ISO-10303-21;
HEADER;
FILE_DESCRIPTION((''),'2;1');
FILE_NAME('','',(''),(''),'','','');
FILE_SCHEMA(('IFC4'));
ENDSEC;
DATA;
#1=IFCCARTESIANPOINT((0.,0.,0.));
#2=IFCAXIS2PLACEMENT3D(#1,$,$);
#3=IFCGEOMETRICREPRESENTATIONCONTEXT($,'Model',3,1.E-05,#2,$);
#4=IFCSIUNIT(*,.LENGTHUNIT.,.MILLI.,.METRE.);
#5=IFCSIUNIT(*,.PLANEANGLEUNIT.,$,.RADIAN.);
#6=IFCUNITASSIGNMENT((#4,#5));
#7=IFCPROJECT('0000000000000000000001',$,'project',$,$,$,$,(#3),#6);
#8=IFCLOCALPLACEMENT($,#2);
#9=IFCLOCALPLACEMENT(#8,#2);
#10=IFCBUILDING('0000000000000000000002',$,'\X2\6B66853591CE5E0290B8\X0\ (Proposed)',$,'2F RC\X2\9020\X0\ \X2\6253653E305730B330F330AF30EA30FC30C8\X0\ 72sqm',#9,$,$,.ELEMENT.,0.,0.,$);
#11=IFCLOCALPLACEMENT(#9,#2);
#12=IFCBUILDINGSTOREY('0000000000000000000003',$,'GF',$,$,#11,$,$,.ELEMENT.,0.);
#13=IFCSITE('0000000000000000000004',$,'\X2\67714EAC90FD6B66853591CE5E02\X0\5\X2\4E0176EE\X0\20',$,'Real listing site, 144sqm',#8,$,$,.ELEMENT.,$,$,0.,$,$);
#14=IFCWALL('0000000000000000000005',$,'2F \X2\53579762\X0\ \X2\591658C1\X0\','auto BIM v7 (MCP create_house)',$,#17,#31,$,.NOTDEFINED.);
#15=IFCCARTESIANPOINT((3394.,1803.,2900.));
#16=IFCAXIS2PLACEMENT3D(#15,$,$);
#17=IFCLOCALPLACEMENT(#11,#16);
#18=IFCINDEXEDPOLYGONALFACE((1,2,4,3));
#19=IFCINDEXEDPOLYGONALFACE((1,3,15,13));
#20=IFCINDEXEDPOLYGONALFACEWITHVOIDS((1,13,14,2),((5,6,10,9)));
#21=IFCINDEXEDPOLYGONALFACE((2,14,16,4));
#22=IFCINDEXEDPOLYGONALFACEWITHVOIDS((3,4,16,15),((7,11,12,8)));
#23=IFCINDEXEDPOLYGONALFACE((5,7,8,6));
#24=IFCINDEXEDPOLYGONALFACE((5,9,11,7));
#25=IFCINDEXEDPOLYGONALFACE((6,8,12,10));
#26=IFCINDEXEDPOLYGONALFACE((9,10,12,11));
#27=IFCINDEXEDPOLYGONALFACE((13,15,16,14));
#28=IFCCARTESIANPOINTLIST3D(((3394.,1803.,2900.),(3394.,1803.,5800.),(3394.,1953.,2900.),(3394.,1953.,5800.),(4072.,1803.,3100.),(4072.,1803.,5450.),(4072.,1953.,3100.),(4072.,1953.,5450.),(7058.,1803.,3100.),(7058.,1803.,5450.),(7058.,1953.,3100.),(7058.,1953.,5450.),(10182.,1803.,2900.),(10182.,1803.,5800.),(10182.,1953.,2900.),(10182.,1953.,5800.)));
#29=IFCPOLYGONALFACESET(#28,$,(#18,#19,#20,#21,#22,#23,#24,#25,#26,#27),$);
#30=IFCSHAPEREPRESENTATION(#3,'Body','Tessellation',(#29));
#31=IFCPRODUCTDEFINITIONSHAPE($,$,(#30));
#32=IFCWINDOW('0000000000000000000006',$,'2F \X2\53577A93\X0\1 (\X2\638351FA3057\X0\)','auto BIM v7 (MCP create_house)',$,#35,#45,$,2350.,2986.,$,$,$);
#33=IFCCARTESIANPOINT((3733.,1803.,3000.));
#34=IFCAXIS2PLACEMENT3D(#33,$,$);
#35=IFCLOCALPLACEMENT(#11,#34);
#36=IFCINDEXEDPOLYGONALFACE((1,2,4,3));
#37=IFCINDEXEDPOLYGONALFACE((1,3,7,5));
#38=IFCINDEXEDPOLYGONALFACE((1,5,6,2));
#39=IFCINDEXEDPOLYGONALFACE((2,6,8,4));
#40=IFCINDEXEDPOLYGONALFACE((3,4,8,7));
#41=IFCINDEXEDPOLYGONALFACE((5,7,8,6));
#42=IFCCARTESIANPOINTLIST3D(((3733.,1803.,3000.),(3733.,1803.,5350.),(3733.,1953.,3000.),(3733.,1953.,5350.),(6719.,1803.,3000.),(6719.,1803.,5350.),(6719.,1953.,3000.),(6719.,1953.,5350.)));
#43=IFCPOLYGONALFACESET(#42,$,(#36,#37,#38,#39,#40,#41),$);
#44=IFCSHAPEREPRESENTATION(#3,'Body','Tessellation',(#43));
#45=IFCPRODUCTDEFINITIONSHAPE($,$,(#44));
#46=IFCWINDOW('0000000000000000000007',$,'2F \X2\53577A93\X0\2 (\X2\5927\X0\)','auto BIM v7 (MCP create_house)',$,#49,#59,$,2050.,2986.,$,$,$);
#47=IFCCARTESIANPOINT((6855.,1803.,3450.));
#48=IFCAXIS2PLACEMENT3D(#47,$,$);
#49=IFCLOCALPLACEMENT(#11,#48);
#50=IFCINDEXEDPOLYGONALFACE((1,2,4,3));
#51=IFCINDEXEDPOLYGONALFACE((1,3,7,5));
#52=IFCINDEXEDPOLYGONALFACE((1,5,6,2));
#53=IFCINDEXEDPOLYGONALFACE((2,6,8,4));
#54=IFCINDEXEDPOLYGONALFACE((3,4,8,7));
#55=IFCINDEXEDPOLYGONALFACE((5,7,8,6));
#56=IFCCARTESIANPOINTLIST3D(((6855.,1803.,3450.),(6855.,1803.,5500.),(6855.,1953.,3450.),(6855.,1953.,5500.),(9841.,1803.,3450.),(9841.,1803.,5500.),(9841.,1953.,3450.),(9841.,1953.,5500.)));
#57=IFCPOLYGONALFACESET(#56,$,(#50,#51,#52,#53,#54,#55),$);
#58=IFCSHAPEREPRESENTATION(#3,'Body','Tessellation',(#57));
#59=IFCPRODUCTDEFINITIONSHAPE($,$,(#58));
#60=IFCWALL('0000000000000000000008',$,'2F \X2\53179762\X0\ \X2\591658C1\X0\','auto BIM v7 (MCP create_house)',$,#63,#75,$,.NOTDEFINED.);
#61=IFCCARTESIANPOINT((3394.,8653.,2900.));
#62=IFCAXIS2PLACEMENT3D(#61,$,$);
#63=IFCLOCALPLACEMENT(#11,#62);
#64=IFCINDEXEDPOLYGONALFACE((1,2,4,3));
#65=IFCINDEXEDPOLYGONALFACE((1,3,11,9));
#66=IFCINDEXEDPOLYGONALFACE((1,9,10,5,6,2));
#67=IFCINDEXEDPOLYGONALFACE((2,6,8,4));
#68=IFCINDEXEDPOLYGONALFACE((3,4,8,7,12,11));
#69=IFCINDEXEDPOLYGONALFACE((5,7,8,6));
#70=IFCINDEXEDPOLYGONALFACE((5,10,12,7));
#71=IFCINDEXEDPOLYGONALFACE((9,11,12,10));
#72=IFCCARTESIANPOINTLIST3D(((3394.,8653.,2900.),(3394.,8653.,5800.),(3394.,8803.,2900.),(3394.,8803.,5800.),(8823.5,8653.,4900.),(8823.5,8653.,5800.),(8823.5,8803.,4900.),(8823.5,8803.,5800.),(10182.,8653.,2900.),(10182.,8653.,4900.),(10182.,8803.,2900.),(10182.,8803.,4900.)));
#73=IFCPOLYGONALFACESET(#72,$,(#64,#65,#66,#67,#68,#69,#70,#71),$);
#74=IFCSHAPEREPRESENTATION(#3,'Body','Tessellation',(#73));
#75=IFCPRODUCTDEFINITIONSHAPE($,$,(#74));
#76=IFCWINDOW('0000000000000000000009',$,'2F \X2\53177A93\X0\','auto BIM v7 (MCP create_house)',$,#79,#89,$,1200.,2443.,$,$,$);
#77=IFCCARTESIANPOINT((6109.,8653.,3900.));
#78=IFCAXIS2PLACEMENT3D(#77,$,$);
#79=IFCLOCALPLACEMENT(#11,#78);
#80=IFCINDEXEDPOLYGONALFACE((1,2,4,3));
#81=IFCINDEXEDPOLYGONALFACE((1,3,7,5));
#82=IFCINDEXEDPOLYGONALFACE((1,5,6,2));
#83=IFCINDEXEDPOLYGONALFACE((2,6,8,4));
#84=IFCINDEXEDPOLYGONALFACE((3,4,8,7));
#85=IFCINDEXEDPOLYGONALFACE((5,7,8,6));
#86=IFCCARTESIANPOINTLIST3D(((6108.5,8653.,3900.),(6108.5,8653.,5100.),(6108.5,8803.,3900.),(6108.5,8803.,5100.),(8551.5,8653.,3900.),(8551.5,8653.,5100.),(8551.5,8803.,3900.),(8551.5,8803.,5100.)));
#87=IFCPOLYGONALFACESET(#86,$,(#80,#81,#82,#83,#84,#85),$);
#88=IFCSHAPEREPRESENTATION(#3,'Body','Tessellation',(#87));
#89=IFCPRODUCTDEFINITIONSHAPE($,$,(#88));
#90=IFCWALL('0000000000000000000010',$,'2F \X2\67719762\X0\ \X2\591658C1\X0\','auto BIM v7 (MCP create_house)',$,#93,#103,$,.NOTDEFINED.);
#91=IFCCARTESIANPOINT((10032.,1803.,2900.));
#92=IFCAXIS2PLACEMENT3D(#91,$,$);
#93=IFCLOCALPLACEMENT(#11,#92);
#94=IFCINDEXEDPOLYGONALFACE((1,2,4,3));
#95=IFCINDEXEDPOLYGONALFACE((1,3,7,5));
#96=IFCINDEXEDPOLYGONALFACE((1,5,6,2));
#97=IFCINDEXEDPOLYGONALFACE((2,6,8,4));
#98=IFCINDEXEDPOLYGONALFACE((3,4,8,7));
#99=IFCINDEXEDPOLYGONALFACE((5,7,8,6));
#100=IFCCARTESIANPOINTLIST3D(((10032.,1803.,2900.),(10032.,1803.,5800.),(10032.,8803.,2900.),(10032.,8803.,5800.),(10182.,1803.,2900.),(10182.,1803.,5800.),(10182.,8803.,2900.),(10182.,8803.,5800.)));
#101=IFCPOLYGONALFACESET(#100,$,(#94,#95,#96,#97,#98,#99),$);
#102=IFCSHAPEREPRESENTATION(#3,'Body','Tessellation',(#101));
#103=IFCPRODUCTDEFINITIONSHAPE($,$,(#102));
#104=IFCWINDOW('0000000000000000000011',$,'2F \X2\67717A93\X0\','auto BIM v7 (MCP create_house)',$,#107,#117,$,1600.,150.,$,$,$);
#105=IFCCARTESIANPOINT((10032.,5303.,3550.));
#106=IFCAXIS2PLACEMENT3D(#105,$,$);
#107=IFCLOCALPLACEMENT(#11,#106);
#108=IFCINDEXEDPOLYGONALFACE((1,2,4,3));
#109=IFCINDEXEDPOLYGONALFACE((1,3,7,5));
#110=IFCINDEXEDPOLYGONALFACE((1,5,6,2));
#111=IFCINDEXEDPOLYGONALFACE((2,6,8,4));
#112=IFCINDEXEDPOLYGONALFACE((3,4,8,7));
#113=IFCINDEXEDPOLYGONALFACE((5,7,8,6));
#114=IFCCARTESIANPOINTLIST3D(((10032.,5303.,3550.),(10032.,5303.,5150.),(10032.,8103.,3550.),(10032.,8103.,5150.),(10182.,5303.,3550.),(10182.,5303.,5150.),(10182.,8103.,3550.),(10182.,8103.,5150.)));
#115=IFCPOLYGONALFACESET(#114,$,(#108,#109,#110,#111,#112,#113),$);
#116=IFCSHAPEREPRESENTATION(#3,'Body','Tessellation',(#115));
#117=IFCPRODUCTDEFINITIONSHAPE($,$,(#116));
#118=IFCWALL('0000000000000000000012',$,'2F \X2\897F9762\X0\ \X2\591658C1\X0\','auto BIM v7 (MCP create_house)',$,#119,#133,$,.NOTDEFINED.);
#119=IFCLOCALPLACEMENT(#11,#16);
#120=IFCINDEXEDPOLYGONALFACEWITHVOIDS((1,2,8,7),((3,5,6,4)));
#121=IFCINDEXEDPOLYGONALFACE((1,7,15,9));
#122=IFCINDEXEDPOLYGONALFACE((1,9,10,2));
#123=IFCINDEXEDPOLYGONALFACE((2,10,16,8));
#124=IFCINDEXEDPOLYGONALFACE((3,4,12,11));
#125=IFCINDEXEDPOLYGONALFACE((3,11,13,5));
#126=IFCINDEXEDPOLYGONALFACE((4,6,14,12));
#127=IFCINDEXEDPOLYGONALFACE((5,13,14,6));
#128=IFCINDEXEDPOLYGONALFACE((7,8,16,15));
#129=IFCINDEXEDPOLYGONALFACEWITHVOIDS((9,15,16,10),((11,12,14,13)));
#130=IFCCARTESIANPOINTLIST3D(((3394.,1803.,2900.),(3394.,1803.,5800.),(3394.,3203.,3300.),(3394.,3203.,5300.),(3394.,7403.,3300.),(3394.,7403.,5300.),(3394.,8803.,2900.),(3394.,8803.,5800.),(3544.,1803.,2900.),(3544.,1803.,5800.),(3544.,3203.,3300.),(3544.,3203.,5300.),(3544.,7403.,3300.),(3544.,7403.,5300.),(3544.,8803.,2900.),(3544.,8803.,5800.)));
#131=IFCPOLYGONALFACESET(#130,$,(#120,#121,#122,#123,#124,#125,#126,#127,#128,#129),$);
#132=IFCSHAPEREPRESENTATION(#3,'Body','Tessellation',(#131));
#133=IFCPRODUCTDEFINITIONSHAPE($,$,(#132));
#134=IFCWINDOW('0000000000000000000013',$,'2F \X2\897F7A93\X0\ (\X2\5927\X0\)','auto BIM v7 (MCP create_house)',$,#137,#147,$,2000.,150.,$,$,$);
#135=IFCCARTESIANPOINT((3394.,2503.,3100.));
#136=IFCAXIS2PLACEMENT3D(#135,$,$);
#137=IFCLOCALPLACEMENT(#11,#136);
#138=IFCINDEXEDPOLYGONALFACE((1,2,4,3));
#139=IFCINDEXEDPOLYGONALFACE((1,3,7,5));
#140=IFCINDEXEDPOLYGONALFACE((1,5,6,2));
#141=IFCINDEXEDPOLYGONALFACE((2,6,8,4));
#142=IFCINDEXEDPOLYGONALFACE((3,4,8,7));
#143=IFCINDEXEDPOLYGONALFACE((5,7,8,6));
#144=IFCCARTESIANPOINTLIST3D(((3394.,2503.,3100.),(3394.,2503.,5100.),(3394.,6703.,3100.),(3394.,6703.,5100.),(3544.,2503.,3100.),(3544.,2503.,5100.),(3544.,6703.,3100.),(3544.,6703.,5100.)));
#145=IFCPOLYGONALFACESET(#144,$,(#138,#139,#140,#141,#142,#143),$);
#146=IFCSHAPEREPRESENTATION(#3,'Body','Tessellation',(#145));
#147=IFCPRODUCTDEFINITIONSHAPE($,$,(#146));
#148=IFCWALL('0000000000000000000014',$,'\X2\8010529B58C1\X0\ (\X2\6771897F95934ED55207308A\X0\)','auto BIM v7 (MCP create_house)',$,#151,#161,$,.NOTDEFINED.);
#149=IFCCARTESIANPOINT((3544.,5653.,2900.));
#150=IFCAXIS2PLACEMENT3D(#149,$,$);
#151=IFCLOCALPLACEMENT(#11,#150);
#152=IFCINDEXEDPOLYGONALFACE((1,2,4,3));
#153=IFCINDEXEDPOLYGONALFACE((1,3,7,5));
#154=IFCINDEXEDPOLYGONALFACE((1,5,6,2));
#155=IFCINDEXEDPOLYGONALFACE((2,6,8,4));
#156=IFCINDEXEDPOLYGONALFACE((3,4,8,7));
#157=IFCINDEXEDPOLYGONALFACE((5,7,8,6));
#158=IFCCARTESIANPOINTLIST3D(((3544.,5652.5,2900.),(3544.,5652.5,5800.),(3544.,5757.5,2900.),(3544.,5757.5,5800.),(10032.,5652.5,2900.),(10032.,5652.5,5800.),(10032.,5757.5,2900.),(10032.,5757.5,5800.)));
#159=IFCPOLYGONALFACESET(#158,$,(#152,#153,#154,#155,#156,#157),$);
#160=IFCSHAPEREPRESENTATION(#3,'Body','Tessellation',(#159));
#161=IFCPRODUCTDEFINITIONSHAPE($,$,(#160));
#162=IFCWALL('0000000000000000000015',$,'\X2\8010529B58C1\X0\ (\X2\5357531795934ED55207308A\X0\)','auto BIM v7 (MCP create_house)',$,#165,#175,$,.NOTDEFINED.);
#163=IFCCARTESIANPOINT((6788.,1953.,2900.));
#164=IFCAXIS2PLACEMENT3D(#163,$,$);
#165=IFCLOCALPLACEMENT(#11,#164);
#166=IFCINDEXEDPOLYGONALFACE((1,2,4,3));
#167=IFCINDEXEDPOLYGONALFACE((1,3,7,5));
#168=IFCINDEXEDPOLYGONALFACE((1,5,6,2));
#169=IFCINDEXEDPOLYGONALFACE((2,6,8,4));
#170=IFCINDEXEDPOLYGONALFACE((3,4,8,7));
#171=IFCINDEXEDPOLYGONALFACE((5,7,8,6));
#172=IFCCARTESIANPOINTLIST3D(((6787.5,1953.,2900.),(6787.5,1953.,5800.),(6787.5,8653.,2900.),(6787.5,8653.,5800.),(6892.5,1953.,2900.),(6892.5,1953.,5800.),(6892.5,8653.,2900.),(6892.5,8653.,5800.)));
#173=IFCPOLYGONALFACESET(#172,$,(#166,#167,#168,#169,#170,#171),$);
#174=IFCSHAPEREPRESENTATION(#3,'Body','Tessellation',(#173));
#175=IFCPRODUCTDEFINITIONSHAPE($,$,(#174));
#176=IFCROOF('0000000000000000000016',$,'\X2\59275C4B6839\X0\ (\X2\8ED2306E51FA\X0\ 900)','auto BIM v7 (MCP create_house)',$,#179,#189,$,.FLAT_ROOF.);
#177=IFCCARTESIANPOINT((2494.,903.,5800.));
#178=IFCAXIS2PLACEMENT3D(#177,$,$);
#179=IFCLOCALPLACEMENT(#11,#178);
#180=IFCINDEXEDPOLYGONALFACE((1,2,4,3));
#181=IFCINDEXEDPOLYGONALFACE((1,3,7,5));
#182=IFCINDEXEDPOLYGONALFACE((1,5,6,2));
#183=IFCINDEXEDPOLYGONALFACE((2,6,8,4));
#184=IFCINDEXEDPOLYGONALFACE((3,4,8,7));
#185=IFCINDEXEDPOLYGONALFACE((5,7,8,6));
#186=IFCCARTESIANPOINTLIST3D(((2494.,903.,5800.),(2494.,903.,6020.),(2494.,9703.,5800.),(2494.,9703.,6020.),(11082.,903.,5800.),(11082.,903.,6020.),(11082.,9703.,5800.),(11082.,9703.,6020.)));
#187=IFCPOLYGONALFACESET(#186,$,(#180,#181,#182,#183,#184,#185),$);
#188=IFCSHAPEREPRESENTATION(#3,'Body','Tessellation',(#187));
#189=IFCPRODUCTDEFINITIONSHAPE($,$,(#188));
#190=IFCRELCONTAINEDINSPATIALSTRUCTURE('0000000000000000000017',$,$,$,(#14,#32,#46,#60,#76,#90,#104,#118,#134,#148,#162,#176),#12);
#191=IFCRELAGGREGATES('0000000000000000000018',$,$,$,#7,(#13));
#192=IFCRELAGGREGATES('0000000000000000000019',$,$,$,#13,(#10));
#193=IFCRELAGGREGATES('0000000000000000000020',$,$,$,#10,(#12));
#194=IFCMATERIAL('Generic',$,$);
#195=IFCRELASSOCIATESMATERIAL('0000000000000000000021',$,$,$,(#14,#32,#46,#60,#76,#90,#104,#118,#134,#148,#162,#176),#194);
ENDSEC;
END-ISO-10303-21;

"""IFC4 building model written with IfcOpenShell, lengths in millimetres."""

from ifc_helpers import new_model, si_unit, frame, frame_2d, origin, place, context, project, spatial, rectangle, extrude, material, element, fill, save


model = new_model("IFC4")

# Units and contexts
model_context = context("Model", 3, precision=1e-05, world=origin())
ifc_project = project(units=[si_unit("LENGTHUNIT", "METRE", prefix="MILLI"), si_unit("PLANEANGLEUNIT", "RADIAN")], contexts=[model_context])

# Site, building, storey
site_placement = place(None, origin())
site = spatial("IfcSite", under=ifc_project, at=site_placement, Name="東京都武蔵野市5丁目20", ObjectType="Real listing site, 144sqm", CompositionType="ELEMENT", RefElevation=0.0)
building_placement = place(site_placement, origin())
building = spatial("IfcBuilding", under=site, at=building_placement, Name="武蔵野市邸 (Proposed)", ObjectType="2F RC造 打放しコンクリート 72sqm", CompositionType="ELEMENT", ElevationOfRefHeight=0.0, ElevationOfTerrain=0.0)
storey_placement = place(building_placement, origin())
storey = spatial("IfcBuildingStorey", under=building, at=storey_placement, Name="GF", CompositionType="ELEMENT", Elevation=0.0)

# Shared definitions
ifc_material = material(Name="Generic")

# Wall, openings, windows
wall_1_placement = place(storey_placement, frame((3394.0, 1803.0, 2900.0)))
wall_1 = element("IfcWall", 1, at=wall_1_placement, inside=storey, material=ifc_material, Name="2F 南面 外壁", Description="auto BIM v7 (MCP create_house)", PredefinedType="NOTDEFINED", context=model_context, shape_type="SweptSolid", body=[
    extrude(rectangle(XDim=6788.0, YDim=150.0, at=frame_2d((3394.0, 75.0))), frame((3394.0, 1803.0, 2900.0)), (0.0, 0.0, 1.0), 2900.0),
])
opening_1_placement = place(storey_placement, frame((3733.0, 1803.0, 3000.0)))
opening_1 = element("IfcOpeningElement", 2, at=opening_1_placement, cuts=wall_1, PredefinedType="NOTDEFINED", context=model_context, shape_type="SweptSolid", body=[
    extrude(rectangle(XDim=2986.0, YDim=150.0, at=frame_2d((1493.0, 75.0))), frame((3733.0, 1803.0, 3000.0)), (0.0, 0.0, 1.0), 2350.0),
])
opening_2_placement = place(storey_placement, frame((6855.0, 1803.0, 3450.0)))
opening_2 = element("IfcOpeningElement", 3, at=opening_2_placement, cuts=wall_1, PredefinedType="NOTDEFINED", context=model_context, shape_type="SweptSolid", body=[
    extrude(rectangle(XDim=2986.0, YDim=150.0, at=frame_2d((1493.0, 75.0))), frame((6855.0, 1803.0, 3450.0)), (0.0, 0.0, 1.0), 2050.0),
])
window_1_placement = place(storey_placement, frame((3733.0, 1803.0, 3000.0)))
window_1 = element("IfcWindow", 4, at=window_1_placement, inside=storey, material=ifc_material, Name="2F 南窓1 (掃出し)", Description="auto BIM v7 (MCP create_house)", OverallHeight=2350.0, OverallWidth=2986.0, context=model_context, shape_type="SweptSolid", body=[
    extrude(rectangle(XDim=2986.0, YDim=150.0, at=frame_2d((1493.0, 75.0))), frame((3733.0, 1803.0, 3000.0)), (0.0, 0.0, 1.0), 2350.0),
])
fill(opening_1, window_1)
window_2_placement = place(storey_placement, frame((6855.0, 1803.0, 3450.0)))
window_2 = element("IfcWindow", 5, at=window_2_placement, inside=storey, material=ifc_material, Name="2F 南窓2 (大)", Description="auto BIM v7 (MCP create_house)", OverallHeight=2050.0, OverallWidth=2986.0, context=model_context, shape_type="SweptSolid", body=[
    extrude(rectangle(XDim=2986.0, YDim=150.0, at=frame_2d((1493.0, 75.0))), frame((6855.0, 1803.0, 3450.0)), (0.0, 0.0, 1.0), 2050.0),
])
fill(opening_2, window_2)

# Walls, openings, windows
wall_2_placement = place(storey_placement, frame((3394.0, 8653.0, 2900.0)))
wall_2 = element("IfcWall", 6, at=wall_2_placement, inside=storey, material=ifc_material, Name="2F 北面 外壁", Description="auto BIM v7 (MCP create_house)", PredefinedType="NOTDEFINED", context=model_context, shape_type="SweptSolid", body=[
    extrude(rectangle(XDim=6788.0, YDim=150.0, at=frame_2d((3394.0, 75.0))), frame((3394.0, 8653.0, 2900.0)), (0.0, 0.0, 1.0), 2900.0),
])
opening_3_placement = place(storey_placement, frame((6109.0, 8653.0, 3900.0)))
opening_3 = element("IfcOpeningElement", 7, at=opening_3_placement, cuts=wall_2, PredefinedType="NOTDEFINED", context=model_context, shape_type="SweptSolid", body=[
    extrude(rectangle(XDim=2443.0, YDim=150.0, at=frame_2d((1221.0, 75.0))), frame((6109.0, 8653.0, 3900.0)), (0.0, 0.0, 1.0), 1200.0),
])
window_3_placement = place(storey_placement, frame((6109.0, 8653.0, 3900.0)))
window_3 = element("IfcWindow", 8, at=window_3_placement, inside=storey, material=ifc_material, Name="2F 北窓", Description="auto BIM v7 (MCP create_house)", OverallHeight=1200.0, OverallWidth=2443.0, context=model_context, shape_type="SweptSolid", body=[
    extrude(rectangle(XDim=2443.0, YDim=150.0, at=frame_2d((1221.0, 75.0))), frame((6109.0, 8653.0, 3900.0)), (0.0, 0.0, 1.0), 1200.0),
])
fill(opening_3, window_3)
wall_3_placement = place(storey_placement, frame((10032.0, 1803.0, 2900.0)))
wall_3 = element("IfcWall", 9, at=wall_3_placement, inside=storey, material=ifc_material, Name="2F 東面 外壁", Description="auto BIM v7 (MCP create_house)", PredefinedType="NOTDEFINED", context=model_context, shape_type="SweptSolid", body=[
    extrude(rectangle(XDim=150.0, YDim=7000.0, at=frame_2d((75.0, 3500.0))), frame((10032.0, 1803.0, 2900.0)), (0.0, 0.0, 1.0), 2900.0),
])
opening_4_placement = place(storey_placement, frame((10032.0, 5303.0, 3550.0)))
opening_4 = element("IfcOpeningElement", 10, at=opening_4_placement, cuts=wall_3, PredefinedType="NOTDEFINED", context=model_context, shape_type="SweptSolid", body=[
    extrude(rectangle(XDim=150.0, YDim=2800.0, at=frame_2d((75.0, 1400.0))), frame((10032.0, 5303.0, 3550.0)), (0.0, 0.0, 1.0), 1600.0),
])
window_4_placement = place(storey_placement, frame((10032.0, 5303.0, 3550.0)))
window_4 = element("IfcWindow", 11, at=window_4_placement, inside=storey, material=ifc_material, Name="2F 東窓", Description="auto BIM v7 (MCP create_house)", OverallHeight=1600.0, OverallWidth=150.0, context=model_context, shape_type="SweptSolid", body=[
    extrude(rectangle(XDim=150.0, YDim=2800.0, at=frame_2d((75.0, 1400.0))), frame((10032.0, 5303.0, 3550.0)), (0.0, 0.0, 1.0), 1600.0),
])
fill(opening_4, window_4)
wall_4_placement = place(storey_placement, frame((3394.0, 1803.0, 2900.0)))
wall_4 = element("IfcWall", 12, at=wall_4_placement, inside=storey, material=ifc_material, Name="2F 西面 外壁", Description="auto BIM v7 (MCP create_house)", PredefinedType="NOTDEFINED", context=model_context, shape_type="SweptSolid", body=[
    extrude(rectangle(XDim=150.0, YDim=7000.0, at=frame_2d((75.0, 3500.0))), frame((3394.0, 1803.0, 2900.0)), (0.0, 0.0, 1.0), 2900.0),
])
opening_5_placement = place(storey_placement, frame((3394.0, 2503.0, 3100.0)))
opening_5 = element("IfcOpeningElement", 13, at=opening_5_placement, cuts=wall_4, PredefinedType="NOTDEFINED", context=model_context, shape_type="SweptSolid", body=[
    extrude(rectangle(XDim=150.0, YDim=4200.0, at=frame_2d((75.0, 2100.0))), frame((3394.0, 2503.0, 3100.0)), (0.0, 0.0, 1.0), 2000.0),
])
window_5_placement = place(storey_placement, frame((3394.0, 2503.0, 3100.0)))
window_5 = element("IfcWindow", 14, at=window_5_placement, inside=storey, material=ifc_material, Name="2F 西窓 (大)", Description="auto BIM v7 (MCP create_house)", OverallHeight=2000.0, OverallWidth=150.0, context=model_context, shape_type="SweptSolid", body=[
    extrude(rectangle(XDim=150.0, YDim=4200.0, at=frame_2d((75.0, 2100.0))), frame((3394.0, 2503.0, 3100.0)), (0.0, 0.0, 1.0), 2000.0),
])
fill(opening_5, window_5)

# Walls
wall_5_placement = place(storey_placement, frame((3544.0, 5653.0, 2900.0)))
element("IfcWall", 15, at=wall_5_placement, inside=storey, material=ifc_material, Name="耐力壁 (東西間仕切り)", Description="auto BIM v7 (MCP create_house)", PredefinedType="NOTDEFINED", context=model_context, shape_type="SweptSolid", body=[
    extrude(rectangle(XDim=6488.0, YDim=105.0, at=frame_2d((3244.0, 52.0))), frame((3544.0, 5653.0, 2900.0)), (0.0, 0.0, 1.0), 2900.0),
])
wall_6_placement = place(storey_placement, frame((6788.0, 1953.0, 2900.0)))
element("IfcWall", 16, at=wall_6_placement, inside=storey, material=ifc_material, Name="耐力壁 (南北間仕切り)", Description="auto BIM v7 (MCP create_house)", PredefinedType="NOTDEFINED", context=model_context, shape_type="SweptSolid", body=[
    extrude(rectangle(XDim=105.0, YDim=6700.0, at=frame_2d((52.0, 3350.0))), frame((6788.0, 1953.0, 2900.0)), (0.0, 0.0, 1.0), 2900.0),
])

# Roof
roof_placement = place(storey_placement, frame((2494.0, 903.0, 5800.0)))
element("IfcRoof", 17, at=roof_placement, inside=storey, material=ifc_material, Name="大屋根 (軒の出 900)", Description="auto BIM v7 (MCP create_house)", PredefinedType="FLAT_ROOF", context=model_context, shape_type="SweptSolid", body=[
    extrude(rectangle(XDim=8588.0, YDim=8800.0, at=frame_2d((4294.0, 4400.0))), frame((2494.0, 903.0, 5800.0)), (0.0, 0.0, 1.0), 220.0),
])

save(model, "model.ifc")
